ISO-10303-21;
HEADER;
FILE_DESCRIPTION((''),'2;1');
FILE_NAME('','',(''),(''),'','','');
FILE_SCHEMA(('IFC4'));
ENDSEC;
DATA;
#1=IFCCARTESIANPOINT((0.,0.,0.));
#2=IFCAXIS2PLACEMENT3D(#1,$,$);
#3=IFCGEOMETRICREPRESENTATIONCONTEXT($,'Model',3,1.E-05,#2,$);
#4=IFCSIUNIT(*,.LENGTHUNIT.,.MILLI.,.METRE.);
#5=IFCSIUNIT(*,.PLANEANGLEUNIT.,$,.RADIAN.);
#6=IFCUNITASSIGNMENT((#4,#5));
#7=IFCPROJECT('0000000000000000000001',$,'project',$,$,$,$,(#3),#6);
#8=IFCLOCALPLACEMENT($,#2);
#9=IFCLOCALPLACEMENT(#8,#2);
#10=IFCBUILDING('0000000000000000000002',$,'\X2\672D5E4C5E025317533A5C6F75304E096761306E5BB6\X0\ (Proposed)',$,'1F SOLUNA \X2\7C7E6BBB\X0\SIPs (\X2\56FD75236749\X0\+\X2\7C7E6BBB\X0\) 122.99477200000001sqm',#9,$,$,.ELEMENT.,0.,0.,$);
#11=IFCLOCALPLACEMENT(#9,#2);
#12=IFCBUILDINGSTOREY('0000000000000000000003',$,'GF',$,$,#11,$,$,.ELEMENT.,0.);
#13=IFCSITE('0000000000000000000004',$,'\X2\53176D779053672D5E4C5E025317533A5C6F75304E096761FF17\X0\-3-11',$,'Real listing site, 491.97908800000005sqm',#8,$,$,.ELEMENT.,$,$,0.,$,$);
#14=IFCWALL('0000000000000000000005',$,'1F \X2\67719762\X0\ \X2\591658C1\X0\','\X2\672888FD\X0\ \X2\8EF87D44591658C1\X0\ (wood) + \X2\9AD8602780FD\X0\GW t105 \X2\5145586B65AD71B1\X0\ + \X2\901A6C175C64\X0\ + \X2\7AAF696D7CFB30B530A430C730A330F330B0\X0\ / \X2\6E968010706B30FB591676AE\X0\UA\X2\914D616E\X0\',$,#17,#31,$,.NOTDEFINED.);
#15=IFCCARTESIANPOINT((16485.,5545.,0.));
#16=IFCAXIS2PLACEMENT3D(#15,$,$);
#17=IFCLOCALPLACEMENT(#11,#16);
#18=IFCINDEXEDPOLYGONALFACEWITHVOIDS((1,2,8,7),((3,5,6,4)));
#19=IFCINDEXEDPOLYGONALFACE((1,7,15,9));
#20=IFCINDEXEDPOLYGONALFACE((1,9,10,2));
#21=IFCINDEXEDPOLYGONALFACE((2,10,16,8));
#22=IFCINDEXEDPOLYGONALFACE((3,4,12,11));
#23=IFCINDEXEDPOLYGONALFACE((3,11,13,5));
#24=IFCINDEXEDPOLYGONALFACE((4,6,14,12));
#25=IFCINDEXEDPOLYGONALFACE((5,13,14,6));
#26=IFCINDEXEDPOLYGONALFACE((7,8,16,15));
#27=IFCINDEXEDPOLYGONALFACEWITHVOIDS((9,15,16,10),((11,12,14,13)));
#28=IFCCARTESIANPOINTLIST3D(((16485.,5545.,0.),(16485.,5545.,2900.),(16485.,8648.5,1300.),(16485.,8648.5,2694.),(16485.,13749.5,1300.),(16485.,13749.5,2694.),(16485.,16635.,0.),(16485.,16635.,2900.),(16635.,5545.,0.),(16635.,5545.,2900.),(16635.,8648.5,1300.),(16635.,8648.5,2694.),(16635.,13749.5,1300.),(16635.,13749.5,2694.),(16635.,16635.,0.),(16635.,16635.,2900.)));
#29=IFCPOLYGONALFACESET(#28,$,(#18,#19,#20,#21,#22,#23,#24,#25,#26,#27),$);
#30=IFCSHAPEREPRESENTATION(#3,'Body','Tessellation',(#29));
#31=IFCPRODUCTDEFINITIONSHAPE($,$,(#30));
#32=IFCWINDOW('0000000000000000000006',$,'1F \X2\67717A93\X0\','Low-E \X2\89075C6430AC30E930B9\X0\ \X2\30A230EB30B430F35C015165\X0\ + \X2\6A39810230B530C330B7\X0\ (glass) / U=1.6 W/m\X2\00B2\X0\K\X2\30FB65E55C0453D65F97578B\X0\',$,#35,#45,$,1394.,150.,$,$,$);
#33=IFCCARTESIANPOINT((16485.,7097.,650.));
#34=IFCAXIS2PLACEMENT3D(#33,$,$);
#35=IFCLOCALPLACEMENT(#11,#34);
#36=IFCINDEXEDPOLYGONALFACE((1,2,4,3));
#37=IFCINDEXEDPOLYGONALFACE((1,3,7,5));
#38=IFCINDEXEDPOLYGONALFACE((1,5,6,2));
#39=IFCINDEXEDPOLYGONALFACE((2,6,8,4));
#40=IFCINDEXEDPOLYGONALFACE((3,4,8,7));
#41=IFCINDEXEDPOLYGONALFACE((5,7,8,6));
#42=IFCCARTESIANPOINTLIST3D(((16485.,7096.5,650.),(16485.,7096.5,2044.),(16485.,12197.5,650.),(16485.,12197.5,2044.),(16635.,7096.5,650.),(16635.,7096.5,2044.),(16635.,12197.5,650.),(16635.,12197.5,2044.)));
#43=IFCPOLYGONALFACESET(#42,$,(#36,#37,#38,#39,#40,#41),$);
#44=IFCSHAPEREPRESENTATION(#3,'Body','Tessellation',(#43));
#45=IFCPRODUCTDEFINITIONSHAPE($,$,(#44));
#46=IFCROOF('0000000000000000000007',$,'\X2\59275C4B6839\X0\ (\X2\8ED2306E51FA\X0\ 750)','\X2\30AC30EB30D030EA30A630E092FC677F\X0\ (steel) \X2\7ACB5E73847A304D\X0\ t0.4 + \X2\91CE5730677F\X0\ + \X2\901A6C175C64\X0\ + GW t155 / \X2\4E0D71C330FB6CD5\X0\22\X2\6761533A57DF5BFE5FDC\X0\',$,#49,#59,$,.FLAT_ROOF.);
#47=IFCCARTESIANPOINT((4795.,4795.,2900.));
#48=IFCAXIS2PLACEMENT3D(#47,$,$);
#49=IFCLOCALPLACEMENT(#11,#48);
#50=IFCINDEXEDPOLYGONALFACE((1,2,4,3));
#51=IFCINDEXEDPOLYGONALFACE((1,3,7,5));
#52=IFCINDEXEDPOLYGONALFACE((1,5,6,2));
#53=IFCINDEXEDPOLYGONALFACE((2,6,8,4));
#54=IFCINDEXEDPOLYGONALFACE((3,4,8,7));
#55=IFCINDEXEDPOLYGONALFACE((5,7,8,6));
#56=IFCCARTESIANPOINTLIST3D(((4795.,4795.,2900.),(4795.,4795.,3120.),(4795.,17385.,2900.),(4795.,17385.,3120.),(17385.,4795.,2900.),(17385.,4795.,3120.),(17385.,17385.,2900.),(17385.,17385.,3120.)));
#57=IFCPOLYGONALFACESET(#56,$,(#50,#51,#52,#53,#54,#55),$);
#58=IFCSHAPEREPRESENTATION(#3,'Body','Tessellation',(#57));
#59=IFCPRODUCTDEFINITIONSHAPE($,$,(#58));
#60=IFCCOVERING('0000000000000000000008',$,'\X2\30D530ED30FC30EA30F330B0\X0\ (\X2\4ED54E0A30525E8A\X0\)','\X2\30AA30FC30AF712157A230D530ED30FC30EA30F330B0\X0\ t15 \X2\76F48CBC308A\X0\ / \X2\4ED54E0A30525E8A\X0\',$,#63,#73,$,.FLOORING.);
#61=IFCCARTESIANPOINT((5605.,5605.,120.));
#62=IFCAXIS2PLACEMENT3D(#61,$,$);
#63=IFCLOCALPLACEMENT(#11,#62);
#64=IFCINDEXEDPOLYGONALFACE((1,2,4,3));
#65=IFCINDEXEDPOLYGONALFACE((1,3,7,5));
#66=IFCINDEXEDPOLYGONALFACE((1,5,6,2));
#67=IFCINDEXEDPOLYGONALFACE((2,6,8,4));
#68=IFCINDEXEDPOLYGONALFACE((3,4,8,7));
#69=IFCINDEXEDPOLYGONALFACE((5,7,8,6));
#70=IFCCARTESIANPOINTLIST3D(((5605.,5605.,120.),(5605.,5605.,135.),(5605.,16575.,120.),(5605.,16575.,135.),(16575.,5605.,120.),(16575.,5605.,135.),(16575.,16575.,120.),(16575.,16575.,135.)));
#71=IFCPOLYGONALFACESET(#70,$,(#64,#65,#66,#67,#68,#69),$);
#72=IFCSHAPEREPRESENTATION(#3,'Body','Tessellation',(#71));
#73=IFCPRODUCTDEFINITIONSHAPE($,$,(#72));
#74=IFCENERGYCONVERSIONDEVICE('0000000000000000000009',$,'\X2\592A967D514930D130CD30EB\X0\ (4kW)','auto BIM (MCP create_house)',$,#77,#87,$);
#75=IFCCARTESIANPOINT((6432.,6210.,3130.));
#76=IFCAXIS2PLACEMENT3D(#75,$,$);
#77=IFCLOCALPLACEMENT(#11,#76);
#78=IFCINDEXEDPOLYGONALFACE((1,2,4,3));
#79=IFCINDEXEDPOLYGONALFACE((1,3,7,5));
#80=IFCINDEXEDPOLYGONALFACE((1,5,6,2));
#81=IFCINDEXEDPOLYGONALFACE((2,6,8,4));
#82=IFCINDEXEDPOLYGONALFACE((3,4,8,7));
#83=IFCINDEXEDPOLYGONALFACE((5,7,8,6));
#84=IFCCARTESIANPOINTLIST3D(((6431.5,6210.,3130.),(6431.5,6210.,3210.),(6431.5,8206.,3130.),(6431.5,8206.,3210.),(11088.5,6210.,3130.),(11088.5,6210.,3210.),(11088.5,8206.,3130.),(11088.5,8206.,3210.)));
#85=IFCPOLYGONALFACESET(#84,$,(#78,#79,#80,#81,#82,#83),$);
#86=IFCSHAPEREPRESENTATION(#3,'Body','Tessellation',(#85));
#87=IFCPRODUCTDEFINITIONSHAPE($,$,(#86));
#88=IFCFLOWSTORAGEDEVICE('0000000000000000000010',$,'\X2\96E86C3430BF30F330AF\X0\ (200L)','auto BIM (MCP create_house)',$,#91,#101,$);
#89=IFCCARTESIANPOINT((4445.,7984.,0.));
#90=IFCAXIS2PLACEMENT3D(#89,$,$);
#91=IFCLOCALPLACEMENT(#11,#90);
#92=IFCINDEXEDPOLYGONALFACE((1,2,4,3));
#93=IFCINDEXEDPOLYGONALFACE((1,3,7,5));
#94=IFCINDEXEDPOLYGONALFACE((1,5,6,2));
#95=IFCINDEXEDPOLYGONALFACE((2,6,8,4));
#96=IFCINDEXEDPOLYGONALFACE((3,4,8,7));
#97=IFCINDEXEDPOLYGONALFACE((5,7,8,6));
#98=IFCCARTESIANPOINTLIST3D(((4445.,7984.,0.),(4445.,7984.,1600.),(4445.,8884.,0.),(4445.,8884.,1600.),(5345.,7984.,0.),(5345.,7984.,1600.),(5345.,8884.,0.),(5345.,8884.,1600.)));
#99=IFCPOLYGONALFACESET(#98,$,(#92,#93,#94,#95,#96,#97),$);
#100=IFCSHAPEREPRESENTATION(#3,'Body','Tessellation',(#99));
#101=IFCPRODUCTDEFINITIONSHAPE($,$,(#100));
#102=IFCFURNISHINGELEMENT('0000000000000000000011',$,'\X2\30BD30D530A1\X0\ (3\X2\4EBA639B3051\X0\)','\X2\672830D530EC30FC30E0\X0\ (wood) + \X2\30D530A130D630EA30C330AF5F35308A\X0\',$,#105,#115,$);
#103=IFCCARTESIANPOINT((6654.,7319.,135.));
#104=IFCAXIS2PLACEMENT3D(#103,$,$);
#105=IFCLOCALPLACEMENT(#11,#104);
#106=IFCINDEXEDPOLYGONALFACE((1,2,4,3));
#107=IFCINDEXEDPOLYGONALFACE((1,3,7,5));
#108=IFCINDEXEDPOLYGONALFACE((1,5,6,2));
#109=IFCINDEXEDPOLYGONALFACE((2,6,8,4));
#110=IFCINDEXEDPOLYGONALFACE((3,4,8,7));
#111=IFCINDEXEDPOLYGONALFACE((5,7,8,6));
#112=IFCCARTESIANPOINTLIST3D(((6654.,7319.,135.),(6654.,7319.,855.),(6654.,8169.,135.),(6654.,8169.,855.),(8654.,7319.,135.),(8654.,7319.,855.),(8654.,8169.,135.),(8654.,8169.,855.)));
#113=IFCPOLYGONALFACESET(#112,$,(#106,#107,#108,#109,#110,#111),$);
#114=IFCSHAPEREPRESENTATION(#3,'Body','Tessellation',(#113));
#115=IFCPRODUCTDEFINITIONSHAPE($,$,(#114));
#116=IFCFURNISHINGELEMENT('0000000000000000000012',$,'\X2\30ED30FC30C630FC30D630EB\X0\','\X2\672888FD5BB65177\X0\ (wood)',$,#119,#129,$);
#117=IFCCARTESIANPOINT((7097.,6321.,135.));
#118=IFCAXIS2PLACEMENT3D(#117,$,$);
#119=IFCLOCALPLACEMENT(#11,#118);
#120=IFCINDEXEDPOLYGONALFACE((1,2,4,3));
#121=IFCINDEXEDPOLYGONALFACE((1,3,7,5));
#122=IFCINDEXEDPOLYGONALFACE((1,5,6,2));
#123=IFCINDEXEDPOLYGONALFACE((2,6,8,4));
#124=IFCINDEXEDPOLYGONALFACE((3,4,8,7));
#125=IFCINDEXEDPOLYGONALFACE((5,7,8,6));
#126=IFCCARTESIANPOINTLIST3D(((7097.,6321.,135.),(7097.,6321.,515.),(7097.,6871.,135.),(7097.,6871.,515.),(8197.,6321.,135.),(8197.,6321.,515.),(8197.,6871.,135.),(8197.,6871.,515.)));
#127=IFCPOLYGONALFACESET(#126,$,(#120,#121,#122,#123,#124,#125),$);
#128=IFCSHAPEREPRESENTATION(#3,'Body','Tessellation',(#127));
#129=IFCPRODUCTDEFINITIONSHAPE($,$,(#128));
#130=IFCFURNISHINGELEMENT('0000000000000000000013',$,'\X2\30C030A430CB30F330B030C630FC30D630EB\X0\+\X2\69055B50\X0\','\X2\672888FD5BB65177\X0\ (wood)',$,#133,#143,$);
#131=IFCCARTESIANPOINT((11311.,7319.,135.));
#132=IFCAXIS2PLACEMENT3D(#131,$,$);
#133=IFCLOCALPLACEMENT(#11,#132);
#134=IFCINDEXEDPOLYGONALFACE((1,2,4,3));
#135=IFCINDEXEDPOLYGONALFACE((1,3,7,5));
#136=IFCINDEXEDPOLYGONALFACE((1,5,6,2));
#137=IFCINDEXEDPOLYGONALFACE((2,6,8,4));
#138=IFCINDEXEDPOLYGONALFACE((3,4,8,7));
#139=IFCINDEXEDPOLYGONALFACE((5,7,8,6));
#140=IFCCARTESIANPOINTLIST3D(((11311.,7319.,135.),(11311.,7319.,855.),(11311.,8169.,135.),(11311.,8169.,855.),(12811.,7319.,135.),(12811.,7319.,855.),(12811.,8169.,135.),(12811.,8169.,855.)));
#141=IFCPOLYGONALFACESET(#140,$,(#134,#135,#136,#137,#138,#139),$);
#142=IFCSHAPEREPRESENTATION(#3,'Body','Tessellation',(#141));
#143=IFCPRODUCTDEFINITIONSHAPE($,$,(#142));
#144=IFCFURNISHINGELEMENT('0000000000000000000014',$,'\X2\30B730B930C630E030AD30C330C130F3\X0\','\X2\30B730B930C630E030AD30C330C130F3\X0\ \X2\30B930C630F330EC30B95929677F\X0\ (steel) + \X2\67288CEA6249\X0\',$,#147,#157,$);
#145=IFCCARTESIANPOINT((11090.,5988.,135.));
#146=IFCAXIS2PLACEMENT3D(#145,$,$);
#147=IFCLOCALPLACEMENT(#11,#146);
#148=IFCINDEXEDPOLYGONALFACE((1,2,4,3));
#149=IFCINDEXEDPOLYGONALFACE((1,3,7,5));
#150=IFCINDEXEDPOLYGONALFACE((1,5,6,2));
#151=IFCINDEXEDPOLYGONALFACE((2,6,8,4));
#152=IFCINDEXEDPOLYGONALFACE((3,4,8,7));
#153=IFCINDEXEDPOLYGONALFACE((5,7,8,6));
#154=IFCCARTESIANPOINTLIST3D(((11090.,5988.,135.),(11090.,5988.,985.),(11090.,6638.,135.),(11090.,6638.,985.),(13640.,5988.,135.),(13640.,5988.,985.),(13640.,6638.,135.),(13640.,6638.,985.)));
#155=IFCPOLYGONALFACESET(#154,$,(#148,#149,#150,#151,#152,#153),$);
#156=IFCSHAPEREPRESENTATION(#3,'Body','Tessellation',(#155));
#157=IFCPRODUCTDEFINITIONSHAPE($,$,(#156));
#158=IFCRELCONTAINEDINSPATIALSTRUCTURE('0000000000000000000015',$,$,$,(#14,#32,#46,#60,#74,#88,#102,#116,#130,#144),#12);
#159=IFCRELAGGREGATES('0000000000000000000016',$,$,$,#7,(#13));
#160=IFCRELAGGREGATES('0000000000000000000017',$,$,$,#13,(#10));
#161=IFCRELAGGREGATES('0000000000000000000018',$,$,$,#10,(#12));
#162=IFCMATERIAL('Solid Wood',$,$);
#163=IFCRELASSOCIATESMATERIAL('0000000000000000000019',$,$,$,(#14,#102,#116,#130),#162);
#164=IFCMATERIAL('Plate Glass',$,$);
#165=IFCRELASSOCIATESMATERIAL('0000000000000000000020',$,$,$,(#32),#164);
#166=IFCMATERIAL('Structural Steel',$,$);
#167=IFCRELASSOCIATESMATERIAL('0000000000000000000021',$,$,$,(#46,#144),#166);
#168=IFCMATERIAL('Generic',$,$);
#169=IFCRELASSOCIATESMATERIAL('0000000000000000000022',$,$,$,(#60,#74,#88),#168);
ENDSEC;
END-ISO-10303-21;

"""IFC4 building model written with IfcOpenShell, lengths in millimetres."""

from ifc_helpers import new_model, si_unit, frame, frame_2d, origin, place, context, project, spatial, rectangle, extrude, material, element, fill, save


model = new_model("IFC4")

# Units and contexts
model_context = context("Model", 3, precision=1e-05, world=origin())
ifc_project = project(units=[si_unit("LENGTHUNIT", "METRE", prefix="MILLI"), si_unit("PLANEANGLEUNIT", "RADIAN")], contexts=[model_context])

# Site, building, storey
site_placement = place(None, origin())
site = spatial("IfcSite", under=ifc_project, at=site_placement, Name="北海道札幌市北区屯田三条７-3-11", ObjectType="Real listing site, 491.97908800000005sqm", CompositionType="ELEMENT", RefElevation=0.0)
building_placement = place(site_placement, origin())
building = spatial("IfcBuilding", under=site, at=building_placement, Name="札幌市北区屯田三条の家 (Proposed)", ObjectType="1F SOLUNA 籾殻SIPs (国産杉+籾殻) 122.99477200000001sqm", CompositionType="ELEMENT", ElevationOfRefHeight=0.0, ElevationOfTerrain=0.0)
storey_placement = place(building_placement, origin())
storey = spatial("IfcBuildingStorey", under=building, at=storey_placement, Name="GF", CompositionType="ELEMENT", Elevation=0.0)

# Shared definitions
ifc_material_1 = material(Name="Solid Wood")

# Shared definitions
ifc_material_2 = material(Name="Plate Glass")

# Wall, opening, window
wall_1_placement = place(storey_placement, frame((16485.0, 5545.0, 0.0)))
wall_1 = element("IfcWall", 1, at=wall_1_placement, inside=storey, material=ifc_material_1, Name="1F 東面 外壁", Description="木製 軸組外壁 (wood) + 高性能GW t105 充填断熱 + 通気層 + 窯業系サイディング / 準耐火・外皮UA配慮", PredefinedType="NOTDEFINED", context=model_context, shape_type="SweptSolid", body=[
    extrude(rectangle(XDim=150.0, YDim=11090.0, at=frame_2d((75.0, 5545.0))), frame((16485.0, 5545.0, 0.0)), (0.0, 0.0, 1.0), 2900.0),
])
opening_1_placement = place(storey_placement, frame((16485.0, 7097.0, 650.0)))
opening_1 = element("IfcOpeningElement", 2, at=opening_1_placement, cuts=wall_1, PredefinedType="NOTDEFINED", context=model_context, shape_type="SweptSolid", body=[
    extrude(rectangle(XDim=150.0, YDim=5101.0, at=frame_2d((75.0, 2550.0))), frame((16485.0, 7097.0, 650.0)), (0.0, 0.0, 1.0), 1394.0),
])
window_1_placement = place(storey_placement, frame((16485.0, 7097.0, 650.0)))
window_1 = element("IfcWindow", 3, at=window_1_placement, inside=storey, material=ifc_material_2, Name="1F 東窓", Description="Low-E 複層ガラス アルゴン封入 + 樹脂サッシ (glass) / U=1.6 W/m²K・日射取得型", OverallHeight=1394.0, OverallWidth=150.0, context=model_context, shape_type="SweptSolid", body=[
    extrude(rectangle(XDim=150.0, YDim=5101.0, at=frame_2d((75.0, 2550.0))), frame((16485.0, 7097.0, 650.0)), (0.0, 0.0, 1.0), 1394.0),
])
fill(opening_1, window_1)

# Roof
ifc_material_3 = material(Name="Structural Steel")
roof_placement = place(storey_placement, frame((4795.0, 4795.0, 2900.0)))
element("IfcRoof", 4, at=roof_placement, inside=storey, material=ifc_material_3, Name="大屋根 (軒の出 750)", Description="ガルバリウム鋼板 (steel) 立平葺き t0.4 + 野地板 + 通気層 + GW t155 / 不燃・法22条区域対応", PredefinedType="FLAT_ROOF", context=model_context, shape_type="SweptSolid", body=[
    extrude(rectangle(XDim=12590.0, YDim=12590.0, at=frame_2d((6295.0, 6295.0))), frame((4795.0, 4795.0, 2900.0)), (0.0, 0.0, 1.0), 220.0),
])

# Covering
ifc_material_4 = material(Name="Generic")
covering_placement = place(storey_placement, frame((5605.0, 5605.0, 120.0)))
element("IfcCovering", 5, at=covering_placement, inside=storey, material=ifc_material_4, Name="フローリング (仕上げ床)", Description="オーク無垢フローリング t15 直貼り / 仕上げ床", PredefinedType="FLOORING", context=model_context, shape_type="SweptSolid", body=[
    extrude(rectangle(XDim=10970.0, YDim=10970.0, at=frame_2d((5485.0, 5485.0))), frame((5605.0, 5605.0, 120.0)), (0.0, 0.0, 1.0), 15.0),
])

# Energy conversion device
energy_conversion_device_placement = place(storey_placement, frame((6432.0, 6210.0, 3130.0)))
element("IfcEnergyConversionDevice", 6, at=energy_conversion_device_placement, inside=storey, material=ifc_material_4, Name="太陽光パネル (4kW)", Description="auto BIM (MCP create_house)", context=model_context, shape_type="SweptSolid", body=[
    extrude(rectangle(XDim=4657.0, YDim=1996.0, at=frame_2d((2328.0, 998.0))), frame((6432.0, 6210.0, 3130.0)), (0.0, 0.0, 1.0), 80.0),
])

# Flow storage device
flow_storage_device_placement = place(storey_placement, frame((4445.0, 7984.0, 0.0)))
element("IfcFlowStorageDevice", 7, at=flow_storage_device_placement, inside=storey, material=ifc_material_4, Name="雨水タンク (200L)", Description="auto BIM (MCP create_house)", context=model_context, shape_type="SweptSolid", body=[
    extrude(rectangle(XDim=900.0, YDim=900.0, at=frame_2d((450.0, 450.0))), frame((4445.0, 7984.0, 0.0)), (0.0, 0.0, 1.0), 1600.0),
])

# Furnishing elements
furnishing_1_placement = place(storey_placement, frame((6654.0, 7319.0, 135.0)))
element("IfcFurnishingElement", 8, at=furnishing_1_placement, inside=storey, material=ifc_material_1, Name="ソファ (3人掛け)", Description="木フレーム (wood) + ファブリック張り", context=model_context, shape_type="SweptSolid", body=[
    extrude(rectangle(XDim=2000.0, YDim=850.0, at=frame_2d((1000.0, 425.0))), frame((6654.0, 7319.0, 135.0)), (0.0, 0.0, 1.0), 720.0),
])
furnishing_2_placement = place(storey_placement, frame((7097.0, 6321.0, 135.0)))
element("IfcFurnishingElement", 9, at=furnishing_2_placement, inside=storey, material=ifc_material_1, Name="ローテーブル", Description="木製家具 (wood)", context=model_context, shape_type="SweptSolid", body=[
    extrude(rectangle(XDim=1100.0, YDim=550.0, at=frame_2d((550.0, 275.0))), frame((7097.0, 6321.0, 135.0)), (0.0, 0.0, 1.0), 380.0),
])
furnishing_3_placement = place(storey_placement, frame((11311.0, 7319.0, 135.0)))
element("IfcFurnishingElement", 10, at=furnishing_3_placement, inside=storey, material=ifc_material_1, Name="ダイニングテーブル+椅子", Description="木製家具 (wood)", context=model_context, shape_type="SweptSolid", body=[
    extrude(rectangle(XDim=1500.0, YDim=850.0, at=frame_2d((750.0, 425.0))), frame((11311.0, 7319.0, 135.0)), (0.0, 0.0, 1.0), 720.0),
])
furnishing_4_placement = place(storey_placement, frame((11090.0, 5988.0, 135.0)))
element("IfcFurnishingElement", 11, at=furnishing_4_placement, inside=storey, material=ifc_material_3, Name="システムキッチン", Description="システムキッチン ステンレス天板 (steel) + 木質扉", context=model_context, shape_type="SweptSolid", body=[
    extrude(rectangle(XDim=2550.0, YDim=650.0, at=frame_2d((1275.0, 325.0))), frame((11090.0, 5988.0, 135.0)), (0.0, 0.0, 1.0), 850.0),
])

save(model, "model.ifc")
